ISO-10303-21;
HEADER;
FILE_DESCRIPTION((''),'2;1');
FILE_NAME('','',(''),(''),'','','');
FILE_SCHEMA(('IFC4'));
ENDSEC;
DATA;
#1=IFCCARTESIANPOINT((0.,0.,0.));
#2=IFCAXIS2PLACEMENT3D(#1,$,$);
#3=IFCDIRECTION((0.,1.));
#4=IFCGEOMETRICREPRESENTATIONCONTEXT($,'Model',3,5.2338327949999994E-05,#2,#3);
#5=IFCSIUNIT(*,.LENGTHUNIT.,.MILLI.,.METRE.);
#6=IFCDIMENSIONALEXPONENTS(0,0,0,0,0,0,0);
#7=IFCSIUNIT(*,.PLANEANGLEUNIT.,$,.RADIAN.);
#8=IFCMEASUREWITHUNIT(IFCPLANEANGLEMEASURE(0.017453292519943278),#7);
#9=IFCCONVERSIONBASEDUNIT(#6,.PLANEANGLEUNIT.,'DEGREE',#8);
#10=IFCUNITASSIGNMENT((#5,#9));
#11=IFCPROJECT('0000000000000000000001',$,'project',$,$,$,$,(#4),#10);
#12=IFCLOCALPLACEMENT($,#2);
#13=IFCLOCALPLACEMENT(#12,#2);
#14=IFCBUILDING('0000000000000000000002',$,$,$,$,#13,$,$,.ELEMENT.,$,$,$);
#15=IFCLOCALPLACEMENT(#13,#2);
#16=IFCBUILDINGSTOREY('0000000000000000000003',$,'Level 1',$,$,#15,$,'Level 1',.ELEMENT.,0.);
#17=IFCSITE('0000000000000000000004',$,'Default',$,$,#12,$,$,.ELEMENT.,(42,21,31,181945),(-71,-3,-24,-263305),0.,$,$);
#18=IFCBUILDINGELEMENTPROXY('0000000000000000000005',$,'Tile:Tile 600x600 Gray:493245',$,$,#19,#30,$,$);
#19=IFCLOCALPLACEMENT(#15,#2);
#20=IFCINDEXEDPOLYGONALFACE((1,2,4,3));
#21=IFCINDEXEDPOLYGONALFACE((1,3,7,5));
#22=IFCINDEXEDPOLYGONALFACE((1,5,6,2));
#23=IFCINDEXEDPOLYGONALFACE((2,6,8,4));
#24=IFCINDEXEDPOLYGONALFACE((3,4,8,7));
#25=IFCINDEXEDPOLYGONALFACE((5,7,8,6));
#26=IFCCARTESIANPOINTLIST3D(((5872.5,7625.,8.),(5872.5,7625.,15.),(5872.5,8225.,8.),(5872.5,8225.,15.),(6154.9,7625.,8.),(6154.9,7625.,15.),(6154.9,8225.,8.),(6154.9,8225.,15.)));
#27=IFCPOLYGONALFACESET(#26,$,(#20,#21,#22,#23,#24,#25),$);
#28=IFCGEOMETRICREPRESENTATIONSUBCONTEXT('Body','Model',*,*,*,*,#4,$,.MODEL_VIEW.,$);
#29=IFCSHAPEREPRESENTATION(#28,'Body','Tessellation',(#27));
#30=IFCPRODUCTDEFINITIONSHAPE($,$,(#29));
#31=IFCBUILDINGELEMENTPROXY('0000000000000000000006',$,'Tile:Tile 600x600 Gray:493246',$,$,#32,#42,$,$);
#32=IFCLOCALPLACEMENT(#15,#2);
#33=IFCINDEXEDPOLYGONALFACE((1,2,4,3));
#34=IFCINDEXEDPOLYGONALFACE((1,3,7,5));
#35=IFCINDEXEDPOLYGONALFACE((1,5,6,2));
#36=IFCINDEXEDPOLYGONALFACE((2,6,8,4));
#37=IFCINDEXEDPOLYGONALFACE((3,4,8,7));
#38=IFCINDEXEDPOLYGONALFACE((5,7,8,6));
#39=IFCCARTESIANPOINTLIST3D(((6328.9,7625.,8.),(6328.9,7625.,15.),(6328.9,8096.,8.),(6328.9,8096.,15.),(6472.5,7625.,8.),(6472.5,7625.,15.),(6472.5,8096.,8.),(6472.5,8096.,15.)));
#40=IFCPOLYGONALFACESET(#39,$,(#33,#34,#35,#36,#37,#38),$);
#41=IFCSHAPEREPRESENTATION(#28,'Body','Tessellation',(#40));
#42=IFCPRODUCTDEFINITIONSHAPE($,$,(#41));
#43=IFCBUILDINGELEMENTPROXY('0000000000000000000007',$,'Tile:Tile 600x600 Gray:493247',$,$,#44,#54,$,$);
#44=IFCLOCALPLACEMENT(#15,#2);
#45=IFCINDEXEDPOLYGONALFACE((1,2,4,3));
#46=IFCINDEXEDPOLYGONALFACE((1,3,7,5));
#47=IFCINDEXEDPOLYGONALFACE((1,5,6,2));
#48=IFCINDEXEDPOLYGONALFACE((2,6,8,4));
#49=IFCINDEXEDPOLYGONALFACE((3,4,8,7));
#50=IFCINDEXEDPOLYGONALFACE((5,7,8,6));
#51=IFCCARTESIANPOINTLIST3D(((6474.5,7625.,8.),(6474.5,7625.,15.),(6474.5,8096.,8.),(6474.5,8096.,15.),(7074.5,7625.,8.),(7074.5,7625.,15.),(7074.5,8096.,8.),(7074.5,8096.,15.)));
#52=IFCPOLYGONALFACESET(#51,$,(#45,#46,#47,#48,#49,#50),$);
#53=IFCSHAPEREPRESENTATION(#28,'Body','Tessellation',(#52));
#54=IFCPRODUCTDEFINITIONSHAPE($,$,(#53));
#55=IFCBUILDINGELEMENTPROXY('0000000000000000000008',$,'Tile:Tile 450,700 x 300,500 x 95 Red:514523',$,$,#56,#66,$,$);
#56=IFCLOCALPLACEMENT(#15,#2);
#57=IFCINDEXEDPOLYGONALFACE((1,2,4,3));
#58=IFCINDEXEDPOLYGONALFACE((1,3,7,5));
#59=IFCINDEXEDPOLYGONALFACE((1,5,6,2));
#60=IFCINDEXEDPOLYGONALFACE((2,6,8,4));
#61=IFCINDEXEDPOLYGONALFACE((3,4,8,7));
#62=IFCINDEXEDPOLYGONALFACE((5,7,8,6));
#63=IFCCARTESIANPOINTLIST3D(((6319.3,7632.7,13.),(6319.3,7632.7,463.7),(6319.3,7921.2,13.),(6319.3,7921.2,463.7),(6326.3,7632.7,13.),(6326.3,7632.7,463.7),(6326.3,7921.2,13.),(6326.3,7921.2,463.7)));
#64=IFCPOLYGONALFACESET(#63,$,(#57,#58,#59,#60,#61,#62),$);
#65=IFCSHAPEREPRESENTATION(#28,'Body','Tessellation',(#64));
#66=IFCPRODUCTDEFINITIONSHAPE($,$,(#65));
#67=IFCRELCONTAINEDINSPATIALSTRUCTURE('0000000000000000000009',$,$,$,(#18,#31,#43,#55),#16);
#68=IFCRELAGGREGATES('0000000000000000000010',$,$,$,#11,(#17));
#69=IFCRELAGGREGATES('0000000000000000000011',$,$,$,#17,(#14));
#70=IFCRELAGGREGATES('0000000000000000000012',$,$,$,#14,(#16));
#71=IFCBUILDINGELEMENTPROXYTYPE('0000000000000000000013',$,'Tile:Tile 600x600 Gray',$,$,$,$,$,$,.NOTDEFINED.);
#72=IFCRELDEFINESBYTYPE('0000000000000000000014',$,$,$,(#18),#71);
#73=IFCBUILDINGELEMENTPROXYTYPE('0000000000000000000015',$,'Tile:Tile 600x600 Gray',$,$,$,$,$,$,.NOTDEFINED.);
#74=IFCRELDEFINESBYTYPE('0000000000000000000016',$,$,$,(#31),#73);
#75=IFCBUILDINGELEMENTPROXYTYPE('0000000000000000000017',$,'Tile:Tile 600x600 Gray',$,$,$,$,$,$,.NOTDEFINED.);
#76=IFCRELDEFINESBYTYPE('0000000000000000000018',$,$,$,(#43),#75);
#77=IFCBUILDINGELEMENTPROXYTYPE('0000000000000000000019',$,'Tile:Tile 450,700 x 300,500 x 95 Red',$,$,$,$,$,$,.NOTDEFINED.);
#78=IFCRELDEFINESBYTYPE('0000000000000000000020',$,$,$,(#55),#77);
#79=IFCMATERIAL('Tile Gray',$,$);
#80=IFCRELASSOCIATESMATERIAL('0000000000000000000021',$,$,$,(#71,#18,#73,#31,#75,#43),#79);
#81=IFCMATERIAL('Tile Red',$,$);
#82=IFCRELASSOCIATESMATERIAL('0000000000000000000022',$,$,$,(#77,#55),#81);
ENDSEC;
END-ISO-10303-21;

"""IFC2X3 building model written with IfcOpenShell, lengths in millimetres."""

from ifc_helpers import new_model, entity, si_unit, converted_unit, direction, frame, frame_2d, origin, origin_2d_with_axis, place, context, subcontext, project, spatial, rectangle, extrude, source, transform, mapped, material, type_object, type_shapes, element, save


model = new_model("IFC2X3")

# Units and contexts
model_context = context("Model", 3, precision=5.2338327949999994e-05, world=origin(), true_north=direction((0.0, 1.0)))
body_context = subcontext(model_context, "Body", "Model", "MODEL_VIEW")
ifc_project = project(units=[si_unit("LENGTHUNIT", "METRE", prefix="MILLI"), converted_unit("PLANEANGLEUNIT", "DEGREE", entity("IfcPlaneAngleMeasure", 0.017453292519943278), si_unit("PLANEANGLEUNIT", "RADIAN"), dimensions=[0, 0, 0, 0, 0, 0, 0])], contexts=[model_context])

# Site, building, storey
site_placement = place(None, origin())
site = spatial("IfcSite", under=ifc_project, at=site_placement, Name="Default", CompositionType="ELEMENT", RefLatitude=(42, 21, 31, 181945), RefLongitude=(-71, -3, -24, -263305), RefElevation=0.0)
building_placement = place(site_placement, origin())
building = spatial("IfcBuilding", under=site, at=building_placement, CompositionType="ELEMENT")
storey_placement = place(building_placement, origin())
storey = spatial("IfcBuildingStorey", under=building, at=storey_placement, Name="Level 1", LongName="Level 1", CompositionType="ELEMENT", Elevation=0.0)

# Building element proxies
ifc_material_1 = material(Name="Tile Red")
ifc_material_2 = material(Name="Tile Gray")
building_element_proxy_type_1 = type_object("IfcBuildingElementProxyType", Name="Tile:Tile 600x600 Gray", PredefinedType="NOTDEFINED", material=ifc_material_2)
shared_shape_1 = source(origin(), body_context, "Body", "SweptSolid", [
    extrude(rectangle(XDim=282.4, YDim=600.0, at=frame_2d((0.0, 0.0), x_axis=(1.0, 0.0))), frame((-300.0, -141.2, 0.0), z_axis=(0.0, 0.0, 1.0), x_axis=(0.0, -1.0, 0.0)), (0.0, 0.0, 1.0), 7.0),
])
type_shapes(building_element_proxy_type_1, [shared_shape_1])
proxy_1_placement = place(storey_placement, frame((6154.9, 7625.0, 8.0), z_axis=(0.0, 0.0, 1.0), x_axis=(0.0, -1.0, 0.0)))
element("IfcBuildingElementProxy", 1, at=proxy_1_placement, inside=storey, type_object=building_element_proxy_type_1, material=ifc_material_2, Name="Tile:Tile 600x600 Gray:493245", context=body_context, shape_type="MappedRepresentation", body=[
    mapped(shared_shape_1, transform((0.0, 0.0, 0.0), scale=1.0)),
])
building_element_proxy_type_2 = type_object("IfcBuildingElementProxyType", Name="Tile:Tile 600x600 Gray", PredefinedType="NOTDEFINED", material=ifc_material_2)
shared_shape_2 = source(origin(), body_context, "Body", "SweptSolid", [
    extrude(rectangle(XDim=471.0, YDim=143.6, at=frame_2d((0.0, 0.0), x_axis=(1.0, 0.0))), frame((-235.5, -71.8, 0.0), z_axis=(0.0, 0.0, 1.0), x_axis=(-1.0, 0.0, 0.0)), (0.0, 0.0, 1.0), 7.0),
])
type_shapes(building_element_proxy_type_2, [shared_shape_2])
proxy_2_placement = place(storey_placement, frame((6472.5, 7625.0, 8.0), z_axis=(0.0, 0.0, 1.0), x_axis=(0.0, -1.0, 0.0)))
element("IfcBuildingElementProxy", 2, at=proxy_2_placement, inside=storey, type_object=building_element_proxy_type_2, material=ifc_material_2, Name="Tile:Tile 600x600 Gray:493246", context=body_context, shape_type="MappedRepresentation", body=[
    mapped(shared_shape_2, transform((0.0, 0.0, 0.0), scale=1.0)),
])
building_element_proxy_type_3 = type_object("IfcBuildingElementProxyType", Name="Tile:Tile 600x600 Gray", PredefinedType="NOTDEFINED", material=ifc_material_2)
shared_shape_3 = source(origin(), body_context, "Body", "SweptSolid", [
    extrude(rectangle(XDim=471.0, YDim=600.0, at=origin_2d_with_axis()), frame((-235.5, -300.0, 0.0), z_axis=(0.0, 0.0, 1.0), x_axis=(-1.0, 0.0, 0.0)), (0.0, 0.0, 1.0), 7.0),
])
type_shapes(building_element_proxy_type_3, [shared_shape_3])
proxy_3_placement = place(storey_placement, frame((7074.5, 7625.0, 8.0), z_axis=(0.0, 0.0, 1.0), x_axis=(0.0, -1.0, 0.0)))
element("IfcBuildingElementProxy", 3, at=proxy_3_placement, inside=storey, type_object=building_element_proxy_type_3, material=ifc_material_2, Name="Tile:Tile 600x600 Gray:493247", context=body_context, shape_type="MappedRepresentation", body=[
    mapped(shared_shape_3, transform((0.0, 0.0, 0.0), scale=1.0)),
])
building_element_proxy_type_4 = type_object("IfcBuildingElementProxyType", Name="Tile:Tile 450,700 x 300,500 x 95 Red", PredefinedType="NOTDEFINED", material=ifc_material_1)
shared_shape_4 = source(origin(), body_context, "Body", "SweptSolid", [
    extrude(rectangle(XDim=288.5, YDim=450.7, at=frame_2d((0.0, 0.0), x_axis=(1.0, 0.0))), frame((-144.2, -225.4, 0.0), z_axis=(0.0, 0.0, 1.0), x_axis=(-1.0, 0.0, 0.0)), (0.0, 0.0, 1.0), 7.0),
])
type_shapes(building_element_proxy_type_4, [shared_shape_4])
proxy_4_placement = place(storey_placement, frame((6319.3, 7632.7, 13.0), z_axis=(1.0, 0.0, 0.0), x_axis=(0.0, -1.0, 0.0)))
element("IfcBuildingElementProxy", 4, at=proxy_4_placement, inside=storey, type_object=building_element_proxy_type_4, material=ifc_material_1, Name="Tile:Tile 450,700 x 300,500 x 95 Red:514523", context=body_context, shape_type="MappedRepresentation", body=[
    mapped(shared_shape_4, transform((0.0, 0.0, 0.0), scale=1.0)),
])

save(model, "model.ifc")
